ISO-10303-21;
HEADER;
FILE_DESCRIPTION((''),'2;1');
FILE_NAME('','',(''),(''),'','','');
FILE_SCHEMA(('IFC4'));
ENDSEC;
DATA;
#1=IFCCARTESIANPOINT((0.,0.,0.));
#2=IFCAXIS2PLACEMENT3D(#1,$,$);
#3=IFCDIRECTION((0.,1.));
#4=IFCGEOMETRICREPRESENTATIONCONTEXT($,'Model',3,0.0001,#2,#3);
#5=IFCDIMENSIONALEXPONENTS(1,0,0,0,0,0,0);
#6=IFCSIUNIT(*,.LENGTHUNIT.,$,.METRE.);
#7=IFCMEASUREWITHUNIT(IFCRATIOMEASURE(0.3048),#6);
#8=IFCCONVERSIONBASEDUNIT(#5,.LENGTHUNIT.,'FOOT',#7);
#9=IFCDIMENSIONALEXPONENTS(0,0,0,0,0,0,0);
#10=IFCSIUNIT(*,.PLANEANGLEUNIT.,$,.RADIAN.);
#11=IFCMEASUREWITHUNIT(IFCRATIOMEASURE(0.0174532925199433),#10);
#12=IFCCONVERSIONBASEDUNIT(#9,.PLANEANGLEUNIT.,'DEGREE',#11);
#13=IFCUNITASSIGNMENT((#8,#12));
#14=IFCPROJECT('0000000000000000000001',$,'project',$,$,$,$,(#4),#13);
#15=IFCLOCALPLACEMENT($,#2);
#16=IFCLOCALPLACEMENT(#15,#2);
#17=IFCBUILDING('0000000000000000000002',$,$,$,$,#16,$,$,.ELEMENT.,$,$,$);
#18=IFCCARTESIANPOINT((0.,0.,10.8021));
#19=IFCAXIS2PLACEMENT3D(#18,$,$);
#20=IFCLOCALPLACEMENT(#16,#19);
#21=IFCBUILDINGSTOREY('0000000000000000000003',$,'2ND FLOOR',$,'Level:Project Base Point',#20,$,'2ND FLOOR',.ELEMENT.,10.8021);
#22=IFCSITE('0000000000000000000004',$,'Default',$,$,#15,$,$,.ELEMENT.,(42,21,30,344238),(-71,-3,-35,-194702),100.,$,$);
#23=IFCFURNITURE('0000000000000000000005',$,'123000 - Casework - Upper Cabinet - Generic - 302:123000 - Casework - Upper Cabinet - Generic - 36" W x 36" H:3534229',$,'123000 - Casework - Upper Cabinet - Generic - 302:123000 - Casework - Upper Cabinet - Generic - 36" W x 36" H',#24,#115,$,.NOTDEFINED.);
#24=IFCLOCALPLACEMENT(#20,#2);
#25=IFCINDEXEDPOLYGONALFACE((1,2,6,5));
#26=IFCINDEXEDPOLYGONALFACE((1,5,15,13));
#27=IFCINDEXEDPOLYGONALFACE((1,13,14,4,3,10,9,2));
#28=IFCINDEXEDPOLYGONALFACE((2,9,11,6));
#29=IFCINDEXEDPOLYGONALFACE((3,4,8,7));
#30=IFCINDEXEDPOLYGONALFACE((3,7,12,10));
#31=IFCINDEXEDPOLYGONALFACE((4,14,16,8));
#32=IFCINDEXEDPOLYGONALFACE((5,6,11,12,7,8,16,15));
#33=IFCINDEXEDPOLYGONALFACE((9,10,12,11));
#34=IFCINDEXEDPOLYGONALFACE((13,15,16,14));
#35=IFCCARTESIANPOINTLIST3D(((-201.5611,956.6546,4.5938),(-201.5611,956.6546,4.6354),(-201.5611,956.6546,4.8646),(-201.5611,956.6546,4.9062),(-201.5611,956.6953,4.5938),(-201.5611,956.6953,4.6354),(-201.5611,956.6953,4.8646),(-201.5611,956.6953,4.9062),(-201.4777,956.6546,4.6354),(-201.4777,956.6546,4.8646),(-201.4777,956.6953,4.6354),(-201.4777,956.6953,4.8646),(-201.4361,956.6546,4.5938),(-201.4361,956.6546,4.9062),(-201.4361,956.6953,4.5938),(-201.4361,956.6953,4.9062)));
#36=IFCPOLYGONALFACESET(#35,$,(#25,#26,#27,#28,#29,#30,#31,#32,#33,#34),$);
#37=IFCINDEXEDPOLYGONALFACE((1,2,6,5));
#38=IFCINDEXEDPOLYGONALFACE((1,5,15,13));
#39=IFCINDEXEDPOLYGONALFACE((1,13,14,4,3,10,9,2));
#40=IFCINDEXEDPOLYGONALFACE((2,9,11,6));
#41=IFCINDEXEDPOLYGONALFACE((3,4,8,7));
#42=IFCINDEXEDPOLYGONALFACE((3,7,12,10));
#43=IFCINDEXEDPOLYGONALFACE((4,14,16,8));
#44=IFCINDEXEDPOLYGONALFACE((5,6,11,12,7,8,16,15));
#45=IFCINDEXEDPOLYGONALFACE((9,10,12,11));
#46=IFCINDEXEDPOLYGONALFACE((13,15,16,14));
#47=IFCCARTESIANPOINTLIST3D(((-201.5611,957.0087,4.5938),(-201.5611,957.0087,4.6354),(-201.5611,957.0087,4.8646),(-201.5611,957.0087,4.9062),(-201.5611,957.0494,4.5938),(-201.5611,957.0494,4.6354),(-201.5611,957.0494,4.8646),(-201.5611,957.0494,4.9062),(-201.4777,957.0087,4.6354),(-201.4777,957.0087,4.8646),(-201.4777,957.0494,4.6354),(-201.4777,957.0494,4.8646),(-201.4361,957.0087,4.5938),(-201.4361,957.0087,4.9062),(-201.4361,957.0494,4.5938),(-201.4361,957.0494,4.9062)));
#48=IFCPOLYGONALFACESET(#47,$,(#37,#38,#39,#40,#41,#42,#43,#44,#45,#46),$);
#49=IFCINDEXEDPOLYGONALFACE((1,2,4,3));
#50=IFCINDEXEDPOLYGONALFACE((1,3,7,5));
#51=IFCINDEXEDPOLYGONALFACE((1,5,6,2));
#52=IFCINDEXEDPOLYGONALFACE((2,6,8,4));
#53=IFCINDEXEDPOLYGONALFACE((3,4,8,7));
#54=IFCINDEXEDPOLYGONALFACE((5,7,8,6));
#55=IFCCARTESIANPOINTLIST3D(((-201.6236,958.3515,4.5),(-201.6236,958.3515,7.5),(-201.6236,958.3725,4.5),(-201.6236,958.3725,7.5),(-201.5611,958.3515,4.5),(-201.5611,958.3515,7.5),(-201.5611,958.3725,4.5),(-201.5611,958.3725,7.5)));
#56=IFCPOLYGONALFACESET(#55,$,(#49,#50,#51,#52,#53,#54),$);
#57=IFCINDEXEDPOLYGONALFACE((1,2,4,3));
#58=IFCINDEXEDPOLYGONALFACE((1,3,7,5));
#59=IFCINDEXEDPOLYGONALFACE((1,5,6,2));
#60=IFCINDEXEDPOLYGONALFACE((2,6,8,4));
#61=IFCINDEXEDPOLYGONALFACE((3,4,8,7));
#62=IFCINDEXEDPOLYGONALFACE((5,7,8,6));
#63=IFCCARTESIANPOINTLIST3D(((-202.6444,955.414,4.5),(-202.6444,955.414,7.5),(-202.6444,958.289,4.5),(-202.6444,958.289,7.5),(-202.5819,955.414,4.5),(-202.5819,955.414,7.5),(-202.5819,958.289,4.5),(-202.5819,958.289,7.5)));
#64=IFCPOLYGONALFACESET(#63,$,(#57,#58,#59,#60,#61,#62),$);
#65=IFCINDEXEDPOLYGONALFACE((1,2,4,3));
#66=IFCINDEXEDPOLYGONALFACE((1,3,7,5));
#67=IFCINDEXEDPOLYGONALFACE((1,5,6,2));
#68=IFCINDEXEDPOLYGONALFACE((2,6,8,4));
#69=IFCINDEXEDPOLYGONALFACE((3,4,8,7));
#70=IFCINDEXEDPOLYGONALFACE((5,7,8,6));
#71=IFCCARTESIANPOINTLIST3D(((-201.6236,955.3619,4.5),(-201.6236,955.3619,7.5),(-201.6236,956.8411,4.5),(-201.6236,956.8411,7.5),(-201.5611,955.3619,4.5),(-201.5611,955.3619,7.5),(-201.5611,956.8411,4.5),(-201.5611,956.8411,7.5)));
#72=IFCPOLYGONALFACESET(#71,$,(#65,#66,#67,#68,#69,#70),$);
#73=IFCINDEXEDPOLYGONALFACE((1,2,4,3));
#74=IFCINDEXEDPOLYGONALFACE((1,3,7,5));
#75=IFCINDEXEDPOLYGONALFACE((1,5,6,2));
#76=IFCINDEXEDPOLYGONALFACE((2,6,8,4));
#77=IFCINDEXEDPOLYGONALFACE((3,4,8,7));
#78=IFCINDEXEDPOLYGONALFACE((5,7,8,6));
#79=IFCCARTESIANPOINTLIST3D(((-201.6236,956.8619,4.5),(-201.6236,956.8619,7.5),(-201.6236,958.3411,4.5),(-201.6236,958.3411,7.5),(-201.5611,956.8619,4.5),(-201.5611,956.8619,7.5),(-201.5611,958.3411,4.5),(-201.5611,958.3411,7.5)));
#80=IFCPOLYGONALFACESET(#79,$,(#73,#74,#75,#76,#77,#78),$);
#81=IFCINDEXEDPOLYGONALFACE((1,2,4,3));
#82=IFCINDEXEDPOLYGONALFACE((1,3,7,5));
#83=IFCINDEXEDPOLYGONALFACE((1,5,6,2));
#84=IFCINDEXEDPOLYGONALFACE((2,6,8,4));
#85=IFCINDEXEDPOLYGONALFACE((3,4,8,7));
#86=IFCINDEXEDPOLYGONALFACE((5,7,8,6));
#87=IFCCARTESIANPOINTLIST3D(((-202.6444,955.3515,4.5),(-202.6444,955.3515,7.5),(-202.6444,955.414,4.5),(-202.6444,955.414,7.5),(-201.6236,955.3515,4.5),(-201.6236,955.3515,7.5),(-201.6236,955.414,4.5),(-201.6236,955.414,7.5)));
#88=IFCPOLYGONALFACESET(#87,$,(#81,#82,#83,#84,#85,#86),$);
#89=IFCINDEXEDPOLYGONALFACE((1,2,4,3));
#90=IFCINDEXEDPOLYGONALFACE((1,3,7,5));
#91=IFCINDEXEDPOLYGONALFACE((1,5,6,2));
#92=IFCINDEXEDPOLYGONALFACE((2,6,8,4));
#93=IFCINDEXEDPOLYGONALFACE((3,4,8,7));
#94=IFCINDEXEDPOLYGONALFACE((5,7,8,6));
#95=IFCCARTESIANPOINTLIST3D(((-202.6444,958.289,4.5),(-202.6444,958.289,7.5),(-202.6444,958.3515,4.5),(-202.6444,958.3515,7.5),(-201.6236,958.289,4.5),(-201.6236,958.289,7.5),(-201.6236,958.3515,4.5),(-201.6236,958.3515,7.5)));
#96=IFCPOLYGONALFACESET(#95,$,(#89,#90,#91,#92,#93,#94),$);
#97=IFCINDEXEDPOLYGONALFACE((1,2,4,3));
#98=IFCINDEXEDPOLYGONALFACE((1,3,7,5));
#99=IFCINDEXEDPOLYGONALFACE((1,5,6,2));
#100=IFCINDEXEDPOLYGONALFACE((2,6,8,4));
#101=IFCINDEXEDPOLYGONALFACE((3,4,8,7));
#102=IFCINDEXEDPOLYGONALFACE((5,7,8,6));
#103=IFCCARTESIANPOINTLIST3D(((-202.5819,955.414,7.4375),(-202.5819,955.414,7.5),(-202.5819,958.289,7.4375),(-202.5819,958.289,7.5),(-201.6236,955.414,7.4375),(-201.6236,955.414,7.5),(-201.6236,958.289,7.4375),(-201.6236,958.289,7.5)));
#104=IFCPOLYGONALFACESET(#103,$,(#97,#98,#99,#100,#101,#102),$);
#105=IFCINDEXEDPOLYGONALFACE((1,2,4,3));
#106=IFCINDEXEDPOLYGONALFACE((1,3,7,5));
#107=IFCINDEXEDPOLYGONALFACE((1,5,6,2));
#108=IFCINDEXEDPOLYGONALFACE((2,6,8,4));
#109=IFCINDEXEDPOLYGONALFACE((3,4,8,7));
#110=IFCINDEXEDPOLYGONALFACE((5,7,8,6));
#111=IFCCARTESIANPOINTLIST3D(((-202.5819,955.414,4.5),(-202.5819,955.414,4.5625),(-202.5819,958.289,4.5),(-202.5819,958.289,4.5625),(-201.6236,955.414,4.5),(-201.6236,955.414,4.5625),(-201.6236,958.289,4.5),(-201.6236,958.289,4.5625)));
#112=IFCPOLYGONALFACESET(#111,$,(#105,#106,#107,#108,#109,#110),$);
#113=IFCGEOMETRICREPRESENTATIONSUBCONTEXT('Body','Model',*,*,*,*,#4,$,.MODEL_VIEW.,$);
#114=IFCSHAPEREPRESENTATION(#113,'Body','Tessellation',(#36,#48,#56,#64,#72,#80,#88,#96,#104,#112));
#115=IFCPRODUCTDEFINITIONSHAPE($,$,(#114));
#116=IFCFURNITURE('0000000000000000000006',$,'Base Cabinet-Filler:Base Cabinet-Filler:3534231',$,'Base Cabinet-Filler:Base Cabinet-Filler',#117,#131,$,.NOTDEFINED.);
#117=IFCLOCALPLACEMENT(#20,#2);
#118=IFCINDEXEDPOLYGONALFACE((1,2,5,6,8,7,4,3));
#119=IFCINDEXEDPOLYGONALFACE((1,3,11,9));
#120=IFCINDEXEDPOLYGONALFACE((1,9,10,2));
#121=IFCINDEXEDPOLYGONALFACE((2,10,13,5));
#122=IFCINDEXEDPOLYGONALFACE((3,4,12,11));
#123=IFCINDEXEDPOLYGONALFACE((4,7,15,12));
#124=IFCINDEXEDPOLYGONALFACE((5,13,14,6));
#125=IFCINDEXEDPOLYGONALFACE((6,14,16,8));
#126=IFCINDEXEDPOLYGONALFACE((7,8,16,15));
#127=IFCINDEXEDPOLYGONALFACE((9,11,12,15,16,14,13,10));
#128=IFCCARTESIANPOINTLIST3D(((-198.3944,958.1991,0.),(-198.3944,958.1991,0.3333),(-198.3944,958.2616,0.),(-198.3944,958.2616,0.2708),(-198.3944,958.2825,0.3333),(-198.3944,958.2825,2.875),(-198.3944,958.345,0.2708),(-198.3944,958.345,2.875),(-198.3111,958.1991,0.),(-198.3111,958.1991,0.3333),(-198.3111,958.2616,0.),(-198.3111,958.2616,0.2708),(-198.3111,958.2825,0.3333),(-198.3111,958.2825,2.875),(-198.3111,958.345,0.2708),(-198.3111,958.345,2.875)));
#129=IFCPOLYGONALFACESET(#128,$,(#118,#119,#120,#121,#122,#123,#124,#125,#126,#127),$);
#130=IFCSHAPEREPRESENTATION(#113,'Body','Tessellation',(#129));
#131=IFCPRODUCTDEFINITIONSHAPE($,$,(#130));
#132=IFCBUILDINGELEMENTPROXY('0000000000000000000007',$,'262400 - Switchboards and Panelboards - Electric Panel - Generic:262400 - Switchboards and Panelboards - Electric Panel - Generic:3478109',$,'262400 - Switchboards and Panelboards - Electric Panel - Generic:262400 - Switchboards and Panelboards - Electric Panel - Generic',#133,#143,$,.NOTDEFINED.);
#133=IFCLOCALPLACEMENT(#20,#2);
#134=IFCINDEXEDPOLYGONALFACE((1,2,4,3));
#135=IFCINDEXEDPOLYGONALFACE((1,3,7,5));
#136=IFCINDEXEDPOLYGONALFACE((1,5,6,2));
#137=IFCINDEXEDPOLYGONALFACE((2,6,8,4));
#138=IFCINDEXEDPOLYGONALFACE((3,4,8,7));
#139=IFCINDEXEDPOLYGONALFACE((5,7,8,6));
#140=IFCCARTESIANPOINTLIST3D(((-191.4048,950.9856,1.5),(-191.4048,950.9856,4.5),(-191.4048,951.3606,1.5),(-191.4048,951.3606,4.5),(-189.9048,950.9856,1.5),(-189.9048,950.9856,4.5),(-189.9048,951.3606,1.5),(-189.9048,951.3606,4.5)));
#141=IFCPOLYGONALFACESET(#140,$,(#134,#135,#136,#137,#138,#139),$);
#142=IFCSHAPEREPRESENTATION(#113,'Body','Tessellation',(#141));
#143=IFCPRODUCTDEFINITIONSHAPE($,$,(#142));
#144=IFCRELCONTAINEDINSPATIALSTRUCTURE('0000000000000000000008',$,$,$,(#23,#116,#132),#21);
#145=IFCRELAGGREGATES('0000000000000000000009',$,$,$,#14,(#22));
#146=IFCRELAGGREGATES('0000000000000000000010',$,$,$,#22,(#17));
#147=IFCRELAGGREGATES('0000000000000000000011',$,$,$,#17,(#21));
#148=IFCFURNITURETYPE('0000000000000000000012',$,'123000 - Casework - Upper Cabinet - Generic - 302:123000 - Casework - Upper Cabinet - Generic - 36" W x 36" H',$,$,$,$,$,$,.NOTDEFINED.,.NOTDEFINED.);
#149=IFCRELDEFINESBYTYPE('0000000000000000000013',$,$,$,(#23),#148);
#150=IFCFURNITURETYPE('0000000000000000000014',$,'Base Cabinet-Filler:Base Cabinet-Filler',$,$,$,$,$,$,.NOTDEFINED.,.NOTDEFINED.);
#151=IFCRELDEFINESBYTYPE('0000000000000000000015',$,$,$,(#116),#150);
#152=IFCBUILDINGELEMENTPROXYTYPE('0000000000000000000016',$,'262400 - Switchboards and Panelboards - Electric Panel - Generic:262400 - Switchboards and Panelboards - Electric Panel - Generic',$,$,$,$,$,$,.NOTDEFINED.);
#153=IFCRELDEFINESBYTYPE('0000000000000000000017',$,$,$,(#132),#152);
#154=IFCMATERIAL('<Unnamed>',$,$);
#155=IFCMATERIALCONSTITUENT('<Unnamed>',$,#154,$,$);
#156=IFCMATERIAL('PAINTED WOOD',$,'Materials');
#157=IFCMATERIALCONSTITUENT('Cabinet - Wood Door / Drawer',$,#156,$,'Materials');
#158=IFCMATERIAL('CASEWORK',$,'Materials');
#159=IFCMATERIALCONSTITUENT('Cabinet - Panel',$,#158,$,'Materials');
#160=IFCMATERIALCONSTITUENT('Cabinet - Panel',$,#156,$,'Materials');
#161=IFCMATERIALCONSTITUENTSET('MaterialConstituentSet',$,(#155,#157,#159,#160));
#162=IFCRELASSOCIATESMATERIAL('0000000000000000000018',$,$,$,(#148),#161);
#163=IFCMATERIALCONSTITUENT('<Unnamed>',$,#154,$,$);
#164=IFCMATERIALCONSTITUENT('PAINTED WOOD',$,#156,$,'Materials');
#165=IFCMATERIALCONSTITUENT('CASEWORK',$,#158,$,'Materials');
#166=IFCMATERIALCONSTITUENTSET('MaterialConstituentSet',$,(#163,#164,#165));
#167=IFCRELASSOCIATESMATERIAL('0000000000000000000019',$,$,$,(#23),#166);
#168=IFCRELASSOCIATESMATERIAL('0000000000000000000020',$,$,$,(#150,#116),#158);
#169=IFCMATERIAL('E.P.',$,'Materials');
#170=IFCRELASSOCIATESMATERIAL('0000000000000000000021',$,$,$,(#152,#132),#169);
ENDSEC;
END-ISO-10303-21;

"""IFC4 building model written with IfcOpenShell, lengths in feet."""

from ifc_helpers import new_model, entity, si_unit, converted_unit, direction, frame, frame_2d, origin, origin_2d_with_axis, place, context, subcontext, project, spatial, polyline, rectangle, outline, extrude, source, transform, mapped, material, constituent, constituent_set, type_object, type_shapes, element, save


model = new_model("IFC4")

# Units and contexts
model_context = context("Model", 3, precision=0.0001, world=origin(), true_north=direction((0.0, 1.0)))
body_context = subcontext(model_context, "Body", "Model", "MODEL_VIEW")
ifc_project = project(units=[converted_unit("LENGTHUNIT", "FOOT", entity("IfcRatioMeasure", 0.3048), si_unit("LENGTHUNIT", "METRE"), dimensions=[1, 0, 0, 0, 0, 0, 0]), converted_unit("PLANEANGLEUNIT", "DEGREE", entity("IfcRatioMeasure", 0.0174532925199433), si_unit("PLANEANGLEUNIT", "RADIAN"), dimensions=[0, 0, 0, 0, 0, 0, 0])], contexts=[model_context])

# Site, building, storey
site_placement = place(None, origin())
site = spatial("IfcSite", under=ifc_project, at=site_placement, Name="Default", CompositionType="ELEMENT", RefLatitude=(42, 21, 30, 344238), RefLongitude=(-71, -3, -35, -194702), RefElevation=100.0)
building_placement = place(site_placement, origin())
building = spatial("IfcBuilding", under=site, at=building_placement, CompositionType="ELEMENT")
storey_placement = place(building_placement, frame((0.0, 0.0, 10.8021)))
storey = spatial("IfcBuildingStorey", under=building, at=storey_placement, Name="2ND FLOOR", ObjectType="Level:Project Base Point", LongName="2ND FLOOR", CompositionType="ELEMENT", Elevation=10.8021)

# Furniture
ifc_material_1 = material(Name="CASEWORK", Category="Materials")
ifc_material_2 = material(Name="PAINTED WOOD", Category="Materials")
ifc_material_3 = material(Name="<Unnamed>")
ifc_constituent_1 = constituent(ifc_material_3, Name="<Unnamed>")
ifc_constituent_2 = constituent(ifc_material_2, Name="PAINTED WOOD", Category="Materials")
ifc_constituent_3 = constituent(ifc_material_1, Name="CASEWORK", Category="Materials")
ifc_constituent_set_1 = constituent_set(constituents=[ifc_constituent_1, ifc_constituent_2, ifc_constituent_3], Name="MaterialConstituentSet")
ifc_constituent_4 = constituent(ifc_material_3, Name="<Unnamed>")
ifc_constituent_5 = constituent(ifc_material_2, Name="Cabinet - Wood Door / Drawer", Category="Materials")
ifc_constituent_6 = constituent(ifc_material_1, Name="Cabinet - Panel", Category="Materials")
ifc_constituent_7 = constituent(ifc_material_2, Name="Cabinet - Panel", Category="Materials")
ifc_constituent_set_2 = constituent_set(constituents=[ifc_constituent_4, ifc_constituent_5, ifc_constituent_6, ifc_constituent_7], Name="MaterialConstituentSet")
furniture_type_1 = type_object("IfcFurnitureType", Name="123000 - Casework - Upper Cabinet - Generic - 302:123000 - Casework - Upper Cabinet - Generic - 36\" W x 36\" H", AssemblyPlace="NOTDEFINED", PredefinedType="NOTDEFINED", material=ifc_constituent_set_2)
shared_shape_1 = source(origin(), body_context, "Body", "SweptSolid", [
    extrude(outline(polyline([(0.1146, -0.0521), (0.1562, -0.0521), (0.1562, 0.0729), (-0.1562, 0.0729), (-0.1562, -0.0521), (-0.1146, -0.0521), (-0.1146, 0.0313), (0.1146, 0.0313), (0.1146, -0.0521)])), frame((1.303, 0.0729, 0.25), z_axis=(1.0, 0.0, 0.0), x_axis=(0.0, 0.0, 1.0)), (0.0, 0.0, 1.0), 0.0407),
    extrude(outline(polyline([(0.1146, -0.0521), (0.1562, -0.0521), (0.1562, 0.0729), (-0.1562, 0.0729), (-0.1562, -0.0521), (-0.1146, -0.0521), (-0.1146, 0.0313), (0.1146, 0.0313), (0.1146, -0.0521)])), frame((1.6572, 0.0729, 0.25), z_axis=(1.0, 0.0, 0.0), x_axis=(0.0, 0.0, 1.0)), (0.0, 0.0, 1.0), 0.0407),
    extrude(rectangle(XDim=0.0625, YDim=0.021, at=frame_2d((0.0, 0.0), x_axis=(1.0, 0.0))), frame((3.0105, 0.1562, 0.0), z_axis=(0.0, 0.0, 1.0), x_axis=(0.0, -1.0, 0.0)), (0.0, 0.0, 1.0), 3.0),
    extrude(rectangle(XDim=0.0625, YDim=2.875, at=origin_2d_with_axis()), frame((1.5, 1.177, 0.0), z_axis=(0.0, 0.0, 1.0), x_axis=(0.0, 1.0, 0.0)), (0.0, 0.0, 1.0), 3.0),
    extrude(rectangle(XDim=0.0625, YDim=1.4792, at=frame_2d((0.0, 0.0), x_axis=(1.0, 0.0))), frame((0.75, 0.1562, 0.0), z_axis=(0.0, 0.0, 1.0), x_axis=(0.0, -1.0, 0.0)), (0.0, 0.0, 1.0), 3.0),
    extrude(rectangle(XDim=0.0625, YDim=1.4792, at=origin_2d_with_axis()), frame((2.25, 0.1562, 0.0), z_axis=(0.0, 0.0, 1.0), x_axis=(0.0, -1.0, 0.0)), (0.0, 0.0, 1.0), 3.0),
    extrude(rectangle(XDim=0.0625, YDim=1.0208, at=origin_2d_with_axis()), frame((0.0312, 0.6979, 0.0), z_axis=(0.0, 0.0, 1.0), x_axis=(-1.0, 0.0, 0.0)), (0.0, 0.0, 1.0), 3.0),
    extrude(rectangle(XDim=0.0625, YDim=1.0208, at=origin_2d_with_axis()), frame((2.9688, 0.6979, 0.0), z_axis=(0.0, 0.0, 1.0), x_axis=(-1.0, 0.0, 0.0)), (0.0, 0.0, 1.0), 3.0),
    extrude(rectangle(XDim=2.875, YDim=0.9583, at=frame_2d((0.0, 0.0), x_axis=(1.0, 0.0))), frame((1.5, 0.6666, 2.9375), z_axis=(0.0, 0.0, 1.0), x_axis=(-1.0, 0.0, 0.0)), (0.0, 0.0, 1.0), 0.0625),
    extrude(rectangle(XDim=2.875, YDim=0.9583, at=frame_2d((0.0, 0.0), x_axis=(1.0, 0.0))), frame((1.5, 0.6666, 0.0), z_axis=(0.0, 0.0, 1.0), x_axis=(-1.0, 0.0, 0.0)), (0.0, 0.0, 1.0), 0.0625),
])
type_shapes(furniture_type_1, [shared_shape_1])
furniture_1_placement = place(storey_placement, frame((-201.4361, 955.3515, 4.5), z_axis=(0.0, 0.0, 1.0), x_axis=(0.0, 1.0, 0.0)))
element("IfcFurniture", 1, at=furniture_1_placement, inside=storey, type_object=furniture_type_1, material=ifc_constituent_set_1, Name="123000 - Casework - Upper Cabinet - Generic - 302:123000 - Casework - Upper Cabinet - Generic - 36\" W x 36\" H:3534229", ObjectType="123000 - Casework - Upper Cabinet - Generic - 302:123000 - Casework - Upper Cabinet - Generic - 36\" W x 36\" H", PredefinedType="NOTDEFINED", context=body_context, shape_type="MappedRepresentation", body=[
    mapped(shared_shape_1, transform((0.0, 0.0, 0.0), scale=1.0)),
])
furniture_type_2 = type_object("IfcFurnitureType", Name="Base Cabinet-Filler:Base Cabinet-Filler", AssemblyPlace="NOTDEFINED", PredefinedType="NOTDEFINED", material=ifc_material_1)
shared_shape_2 = source(origin(), body_context, "Body", "SweptSolid", [
    extrude(outline(polyline([(-0.0729, 0.599), (-0.0729, -2.0052), (-0.0104, -2.0052), (-0.0104, 0.5365), (0.0729, 0.5365), (0.0729, 0.8698), (0.0104, 0.8698), (0.0104, 0.599), (-0.0729, 0.599)])), frame((0.0, 0.0729, 0.8698), z_axis=(-1.0, 0.0, 0.0), x_axis=(0.0, 1.0, 0.0)), (0.0, 0.0, -1.0), 0.0833),
])
type_shapes(furniture_type_2, [shared_shape_2])
furniture_2_placement = place(storey_placement, frame((-198.3111, 958.345, 0.0), z_axis=(0.0, 0.0, 1.0), x_axis=(-1.0, 0.0, 0.0)))
element("IfcFurniture", 2, at=furniture_2_placement, inside=storey, type_object=furniture_type_2, material=ifc_material_1, Name="Base Cabinet-Filler:Base Cabinet-Filler:3534231", ObjectType="Base Cabinet-Filler:Base Cabinet-Filler", PredefinedType="NOTDEFINED", context=body_context, shape_type="MappedRepresentation", body=[
    mapped(shared_shape_2, transform((0.0, 0.0, 0.0), scale=1.0)),
])

# Building element proxy
ifc_material_4 = material(Name="E.P.", Category="Materials")
building_element_proxy_type_1 = type_object("IfcBuildingElementProxyType", Name="262400 - Switchboards and Panelboards - Electric Panel - Generic:262400 - Switchboards and Panelboards - Electric Panel - Generic", PredefinedType="NOTDEFINED", material=ifc_material_4)
shared_shape_3 = source(origin(), body_context, "Body", "SweptSolid", [
    extrude(rectangle(XDim=0.375, YDim=1.5, at=origin_2d_with_axis()), frame((0.75, 0.1875, 0.0), z_axis=(0.0, 0.0, 1.0), x_axis=(0.0, 1.0, 0.0)), (0.0, 0.0, 1.0), 3.0),
])
type_shapes(building_element_proxy_type_1, [shared_shape_3])
proxy_1_placement = place(storey_placement, frame((-191.4048, 950.9856, 1.5)))
element("IfcBuildingElementProxy", 3, at=proxy_1_placement, inside=storey, type_object=building_element_proxy_type_1, material=ifc_material_4, Name="262400 - Switchboards and Panelboards - Electric Panel - Generic:262400 - Switchboards and Panelboards - Electric Panel - Generic:3478109", ObjectType="262400 - Switchboards and Panelboards - Electric Panel - Generic:262400 - Switchboards and Panelboards - Electric Panel - Generic", PredefinedType="NOTDEFINED", context=body_context, shape_type="MappedRepresentation", body=[
    mapped(shared_shape_3, transform((0.0, 0.0, 0.0), scale=1.0)),
])

save(model, "model.ifc")
